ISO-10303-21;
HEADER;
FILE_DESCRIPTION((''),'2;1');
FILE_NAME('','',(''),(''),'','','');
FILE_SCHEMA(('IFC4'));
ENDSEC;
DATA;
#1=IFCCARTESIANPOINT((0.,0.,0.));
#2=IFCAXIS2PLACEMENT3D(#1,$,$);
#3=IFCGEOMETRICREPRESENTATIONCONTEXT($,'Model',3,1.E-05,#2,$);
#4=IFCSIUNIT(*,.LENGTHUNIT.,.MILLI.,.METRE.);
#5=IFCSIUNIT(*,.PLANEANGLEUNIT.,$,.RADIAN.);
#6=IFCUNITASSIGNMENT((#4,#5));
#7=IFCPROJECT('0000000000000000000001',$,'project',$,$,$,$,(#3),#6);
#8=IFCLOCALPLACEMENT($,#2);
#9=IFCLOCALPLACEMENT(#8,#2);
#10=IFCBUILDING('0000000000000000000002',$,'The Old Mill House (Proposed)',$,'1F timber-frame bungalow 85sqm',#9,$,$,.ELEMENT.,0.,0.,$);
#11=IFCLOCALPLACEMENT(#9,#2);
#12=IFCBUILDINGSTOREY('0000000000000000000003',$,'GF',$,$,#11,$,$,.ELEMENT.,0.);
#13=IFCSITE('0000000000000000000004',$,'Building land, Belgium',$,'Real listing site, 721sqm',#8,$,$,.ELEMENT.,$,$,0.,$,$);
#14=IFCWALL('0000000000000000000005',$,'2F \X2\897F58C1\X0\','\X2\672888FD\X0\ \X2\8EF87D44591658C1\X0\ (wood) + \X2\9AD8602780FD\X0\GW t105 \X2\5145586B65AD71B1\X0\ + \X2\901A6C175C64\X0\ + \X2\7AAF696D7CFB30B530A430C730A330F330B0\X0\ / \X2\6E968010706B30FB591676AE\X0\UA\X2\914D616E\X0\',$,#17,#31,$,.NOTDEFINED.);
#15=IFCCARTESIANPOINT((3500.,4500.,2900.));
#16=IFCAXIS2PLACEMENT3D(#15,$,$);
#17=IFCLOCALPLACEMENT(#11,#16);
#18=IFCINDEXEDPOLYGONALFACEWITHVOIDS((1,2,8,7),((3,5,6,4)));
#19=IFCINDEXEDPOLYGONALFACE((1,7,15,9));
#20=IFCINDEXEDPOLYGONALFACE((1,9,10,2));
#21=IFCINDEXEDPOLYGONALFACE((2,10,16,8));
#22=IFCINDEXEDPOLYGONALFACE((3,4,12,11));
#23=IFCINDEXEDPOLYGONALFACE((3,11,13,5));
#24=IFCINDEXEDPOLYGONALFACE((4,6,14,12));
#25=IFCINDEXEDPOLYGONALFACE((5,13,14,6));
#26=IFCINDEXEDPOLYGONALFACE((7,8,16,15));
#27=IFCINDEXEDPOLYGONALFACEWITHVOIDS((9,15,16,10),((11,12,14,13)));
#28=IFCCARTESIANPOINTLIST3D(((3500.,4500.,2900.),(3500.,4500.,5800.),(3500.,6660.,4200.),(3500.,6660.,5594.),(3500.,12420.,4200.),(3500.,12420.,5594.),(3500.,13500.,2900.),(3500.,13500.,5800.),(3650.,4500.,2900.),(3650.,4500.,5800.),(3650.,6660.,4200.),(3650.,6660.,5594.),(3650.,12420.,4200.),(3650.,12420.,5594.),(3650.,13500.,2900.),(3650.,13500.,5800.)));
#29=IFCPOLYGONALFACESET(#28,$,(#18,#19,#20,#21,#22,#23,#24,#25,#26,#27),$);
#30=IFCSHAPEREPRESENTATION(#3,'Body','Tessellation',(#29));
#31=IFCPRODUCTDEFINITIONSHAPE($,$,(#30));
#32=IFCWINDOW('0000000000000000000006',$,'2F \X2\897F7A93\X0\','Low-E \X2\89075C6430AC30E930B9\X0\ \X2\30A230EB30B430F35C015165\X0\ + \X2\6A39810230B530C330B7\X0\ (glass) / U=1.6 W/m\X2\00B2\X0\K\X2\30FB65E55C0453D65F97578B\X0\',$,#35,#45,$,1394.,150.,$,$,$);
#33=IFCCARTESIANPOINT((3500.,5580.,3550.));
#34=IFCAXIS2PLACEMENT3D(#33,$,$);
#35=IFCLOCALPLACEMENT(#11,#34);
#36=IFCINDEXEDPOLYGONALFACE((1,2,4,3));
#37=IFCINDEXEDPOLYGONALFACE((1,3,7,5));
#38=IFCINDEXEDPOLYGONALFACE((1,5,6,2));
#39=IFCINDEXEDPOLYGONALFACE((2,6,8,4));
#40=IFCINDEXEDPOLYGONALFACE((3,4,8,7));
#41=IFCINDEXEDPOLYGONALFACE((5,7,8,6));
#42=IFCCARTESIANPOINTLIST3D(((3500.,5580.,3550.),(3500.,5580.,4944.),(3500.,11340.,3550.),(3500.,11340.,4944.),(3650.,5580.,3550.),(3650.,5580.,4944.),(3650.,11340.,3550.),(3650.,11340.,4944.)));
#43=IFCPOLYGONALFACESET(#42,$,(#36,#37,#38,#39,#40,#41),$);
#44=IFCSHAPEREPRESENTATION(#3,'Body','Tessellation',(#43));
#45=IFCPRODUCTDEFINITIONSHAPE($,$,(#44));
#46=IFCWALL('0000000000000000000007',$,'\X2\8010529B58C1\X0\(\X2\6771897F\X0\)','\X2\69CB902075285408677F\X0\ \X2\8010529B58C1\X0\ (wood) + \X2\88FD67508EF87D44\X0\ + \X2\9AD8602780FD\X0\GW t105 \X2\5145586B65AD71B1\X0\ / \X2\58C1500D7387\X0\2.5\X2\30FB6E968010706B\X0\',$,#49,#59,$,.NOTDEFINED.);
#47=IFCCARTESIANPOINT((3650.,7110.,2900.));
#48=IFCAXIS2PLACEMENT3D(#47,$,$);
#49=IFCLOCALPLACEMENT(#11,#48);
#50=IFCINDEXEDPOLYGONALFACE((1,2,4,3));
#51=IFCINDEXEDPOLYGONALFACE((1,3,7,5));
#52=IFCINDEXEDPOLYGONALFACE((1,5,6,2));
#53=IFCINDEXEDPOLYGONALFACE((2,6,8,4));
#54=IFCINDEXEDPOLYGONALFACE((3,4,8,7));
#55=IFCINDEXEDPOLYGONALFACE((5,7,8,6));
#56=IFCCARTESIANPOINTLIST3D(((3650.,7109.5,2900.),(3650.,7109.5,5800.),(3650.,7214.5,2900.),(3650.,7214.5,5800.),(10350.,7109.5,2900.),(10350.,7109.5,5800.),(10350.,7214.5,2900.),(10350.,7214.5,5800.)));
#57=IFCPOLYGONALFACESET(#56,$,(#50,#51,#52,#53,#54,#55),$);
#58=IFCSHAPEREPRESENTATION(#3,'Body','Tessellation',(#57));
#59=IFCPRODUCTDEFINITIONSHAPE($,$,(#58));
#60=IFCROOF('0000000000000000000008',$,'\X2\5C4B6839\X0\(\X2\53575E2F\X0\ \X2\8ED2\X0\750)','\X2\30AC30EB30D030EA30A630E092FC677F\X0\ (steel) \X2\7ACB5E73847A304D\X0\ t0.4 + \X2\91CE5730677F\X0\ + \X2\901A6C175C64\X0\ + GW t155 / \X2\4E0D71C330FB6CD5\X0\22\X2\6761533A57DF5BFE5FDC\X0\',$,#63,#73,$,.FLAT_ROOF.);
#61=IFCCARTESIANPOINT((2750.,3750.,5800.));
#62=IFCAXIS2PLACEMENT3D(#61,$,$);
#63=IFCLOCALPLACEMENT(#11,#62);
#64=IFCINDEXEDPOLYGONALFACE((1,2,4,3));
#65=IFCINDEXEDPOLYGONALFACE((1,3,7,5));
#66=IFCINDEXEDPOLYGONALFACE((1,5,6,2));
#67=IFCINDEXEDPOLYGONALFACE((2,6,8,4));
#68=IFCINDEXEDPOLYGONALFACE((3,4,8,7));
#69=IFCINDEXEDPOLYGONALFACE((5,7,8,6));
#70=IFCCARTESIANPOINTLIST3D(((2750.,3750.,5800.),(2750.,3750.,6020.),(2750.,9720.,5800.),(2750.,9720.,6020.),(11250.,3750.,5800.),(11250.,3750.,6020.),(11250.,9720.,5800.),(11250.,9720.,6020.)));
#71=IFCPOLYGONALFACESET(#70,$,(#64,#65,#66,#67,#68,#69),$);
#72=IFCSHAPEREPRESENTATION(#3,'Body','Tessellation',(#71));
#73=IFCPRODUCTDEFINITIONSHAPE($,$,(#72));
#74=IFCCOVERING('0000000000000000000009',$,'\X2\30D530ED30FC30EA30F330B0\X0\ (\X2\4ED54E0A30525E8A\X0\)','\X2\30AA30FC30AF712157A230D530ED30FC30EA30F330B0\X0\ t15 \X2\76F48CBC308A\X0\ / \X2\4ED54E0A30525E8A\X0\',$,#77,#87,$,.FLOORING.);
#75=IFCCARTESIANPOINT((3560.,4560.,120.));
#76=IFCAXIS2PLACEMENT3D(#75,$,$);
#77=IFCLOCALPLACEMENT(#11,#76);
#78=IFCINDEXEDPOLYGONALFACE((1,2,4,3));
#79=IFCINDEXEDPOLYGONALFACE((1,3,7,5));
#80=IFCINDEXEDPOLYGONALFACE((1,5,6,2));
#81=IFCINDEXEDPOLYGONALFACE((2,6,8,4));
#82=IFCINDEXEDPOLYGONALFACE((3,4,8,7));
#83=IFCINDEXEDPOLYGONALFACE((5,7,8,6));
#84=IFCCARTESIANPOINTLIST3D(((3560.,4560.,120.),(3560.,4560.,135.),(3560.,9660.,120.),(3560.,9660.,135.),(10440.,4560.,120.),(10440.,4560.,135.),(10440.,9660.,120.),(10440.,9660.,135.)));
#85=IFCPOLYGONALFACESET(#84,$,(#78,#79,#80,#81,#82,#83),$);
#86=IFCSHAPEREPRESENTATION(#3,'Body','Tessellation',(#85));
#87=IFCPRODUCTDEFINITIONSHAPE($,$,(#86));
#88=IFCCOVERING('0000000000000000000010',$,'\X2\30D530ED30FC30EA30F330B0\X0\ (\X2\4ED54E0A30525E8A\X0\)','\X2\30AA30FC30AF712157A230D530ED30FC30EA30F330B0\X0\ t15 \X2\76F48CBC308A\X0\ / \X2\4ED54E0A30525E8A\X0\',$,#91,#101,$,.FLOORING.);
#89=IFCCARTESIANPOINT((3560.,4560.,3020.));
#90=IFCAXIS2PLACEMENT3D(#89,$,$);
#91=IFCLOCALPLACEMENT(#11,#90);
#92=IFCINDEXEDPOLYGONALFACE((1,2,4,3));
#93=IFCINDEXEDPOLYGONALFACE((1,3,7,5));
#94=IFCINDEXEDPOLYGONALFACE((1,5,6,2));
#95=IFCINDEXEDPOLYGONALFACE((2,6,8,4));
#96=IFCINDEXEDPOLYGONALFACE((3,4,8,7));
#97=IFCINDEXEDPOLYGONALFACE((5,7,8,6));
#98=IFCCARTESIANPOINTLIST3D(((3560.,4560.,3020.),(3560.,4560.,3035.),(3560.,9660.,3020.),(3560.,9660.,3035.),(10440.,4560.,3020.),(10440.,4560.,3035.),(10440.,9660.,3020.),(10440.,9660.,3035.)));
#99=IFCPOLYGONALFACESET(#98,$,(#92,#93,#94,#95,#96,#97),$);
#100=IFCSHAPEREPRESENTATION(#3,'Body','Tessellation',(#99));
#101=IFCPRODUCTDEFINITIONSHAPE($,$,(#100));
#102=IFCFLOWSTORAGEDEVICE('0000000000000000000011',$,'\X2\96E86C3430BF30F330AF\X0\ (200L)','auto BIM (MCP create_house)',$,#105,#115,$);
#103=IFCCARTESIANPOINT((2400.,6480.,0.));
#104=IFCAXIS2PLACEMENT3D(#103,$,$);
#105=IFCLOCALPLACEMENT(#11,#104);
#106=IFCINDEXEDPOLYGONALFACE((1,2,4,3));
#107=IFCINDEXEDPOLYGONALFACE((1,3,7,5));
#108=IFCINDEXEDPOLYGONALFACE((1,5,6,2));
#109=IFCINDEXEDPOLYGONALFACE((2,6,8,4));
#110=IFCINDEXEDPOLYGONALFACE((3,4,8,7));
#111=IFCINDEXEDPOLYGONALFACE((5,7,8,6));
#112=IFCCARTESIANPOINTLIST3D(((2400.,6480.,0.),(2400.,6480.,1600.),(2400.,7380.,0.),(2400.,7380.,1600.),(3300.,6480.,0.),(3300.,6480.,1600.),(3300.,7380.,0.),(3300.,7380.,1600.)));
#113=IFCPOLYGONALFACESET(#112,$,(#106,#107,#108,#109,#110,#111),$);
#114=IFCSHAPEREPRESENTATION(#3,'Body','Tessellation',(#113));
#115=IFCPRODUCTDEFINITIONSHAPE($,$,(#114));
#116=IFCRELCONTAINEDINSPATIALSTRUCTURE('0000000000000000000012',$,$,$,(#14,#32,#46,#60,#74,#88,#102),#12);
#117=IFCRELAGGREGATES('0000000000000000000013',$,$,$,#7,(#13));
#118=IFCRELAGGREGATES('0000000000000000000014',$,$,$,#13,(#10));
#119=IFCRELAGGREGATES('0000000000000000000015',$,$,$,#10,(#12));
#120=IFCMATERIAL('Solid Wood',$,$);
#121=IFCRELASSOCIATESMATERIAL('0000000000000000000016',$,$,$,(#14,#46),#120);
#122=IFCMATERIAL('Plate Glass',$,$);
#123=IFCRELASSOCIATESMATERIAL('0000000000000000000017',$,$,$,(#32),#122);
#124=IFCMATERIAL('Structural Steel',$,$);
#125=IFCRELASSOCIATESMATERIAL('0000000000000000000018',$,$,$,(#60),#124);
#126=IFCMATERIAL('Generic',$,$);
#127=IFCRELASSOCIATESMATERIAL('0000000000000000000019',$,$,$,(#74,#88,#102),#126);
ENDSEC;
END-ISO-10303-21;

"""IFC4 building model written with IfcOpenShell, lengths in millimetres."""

from ifc_helpers import new_model, si_unit, frame, frame_2d, origin, place, context, project, spatial, rectangle, extrude, material, element, fill, save


model = new_model("IFC4")

# Units and contexts
model_context = context("Model", 3, precision=1e-05, world=origin())
ifc_project = project(units=[si_unit("LENGTHUNIT", "METRE", prefix="MILLI"), si_unit("PLANEANGLEUNIT", "RADIAN")], contexts=[model_context])

# Site, building, storey
site_placement = place(None, origin())
site = spatial("IfcSite", under=ifc_project, at=site_placement, Name="Building land, Belgium", ObjectType="Real listing site, 721sqm", CompositionType="ELEMENT", RefElevation=0.0)
building_placement = place(site_placement, origin())
building = spatial("IfcBuilding", under=site, at=building_placement, Name="The Old Mill House (Proposed)", ObjectType="1F timber-frame bungalow 85sqm", CompositionType="ELEMENT", ElevationOfRefHeight=0.0, ElevationOfTerrain=0.0)
storey_placement = place(building_placement, origin())
storey = spatial("IfcBuildingStorey", under=building, at=storey_placement, Name="GF", CompositionType="ELEMENT", Elevation=0.0)

# Shared definitions
ifc_material_1 = material(Name="Solid Wood")
ifc_material_2 = material(Name="Generic")

# Shared definitions
ifc_material_3 = material(Name="Plate Glass")

# Wall, opening, window
wall_1_placement = place(storey_placement, frame((3500.0, 4500.0, 2900.0)))
wall_1 = element("IfcWall", 1, at=wall_1_placement, inside=storey, material=ifc_material_1, Name="2F 西壁", Description="木製 軸組外壁 (wood) + 高性能GW t105 充填断熱 + 通気層 + 窯業系サイディング / 準耐火・外皮UA配慮", PredefinedType="NOTDEFINED", context=model_context, shape_type="SweptSolid", body=[
    extrude(rectangle(XDim=150.0, YDim=9000.0, at=frame_2d((75.0, 4500.0))), frame((3500.0, 4500.0, 2900.0)), (0.0, 0.0, 1.0), 2900.0),
])
opening_1_placement = place(storey_placement, frame((3500.0, 5580.0, 3550.0)))
opening_1 = element("IfcOpeningElement", 2, at=opening_1_placement, cuts=wall_1, PredefinedType="NOTDEFINED", context=model_context, shape_type="SweptSolid", body=[
    extrude(rectangle(XDim=150.0, YDim=5760.0, at=frame_2d((75.0, 2880.0))), frame((3500.0, 5580.0, 3550.0)), (0.0, 0.0, 1.0), 1394.0),
])
window_1_placement = place(storey_placement, frame((3500.0, 5580.0, 3550.0)))
window_1 = element("IfcWindow", 3, at=window_1_placement, inside=storey, material=ifc_material_3, Name="2F 西窓", Description="Low-E 複層ガラス アルゴン封入 + 樹脂サッシ (glass) / U=1.6 W/m²K・日射取得型", OverallHeight=1394.0, OverallWidth=150.0, context=model_context, shape_type="SweptSolid", body=[
    extrude(rectangle(XDim=150.0, YDim=5760.0, at=frame_2d((75.0, 2880.0))), frame((3500.0, 5580.0, 3550.0)), (0.0, 0.0, 1.0), 1394.0),
])
fill(opening_1, window_1)

# Wall
wall_2_placement = place(storey_placement, frame((3650.0, 7110.0, 2900.0)))
element("IfcWall", 4, at=wall_2_placement, inside=storey, material=ifc_material_1, Name="耐力壁(東西)", Description="構造用合板 耐力壁 (wood) + 製材軸組 + 高性能GW t105 充填断熱 / 壁倍率2.5・準耐火", PredefinedType="NOTDEFINED", context=model_context, shape_type="SweptSolid", body=[
    extrude(rectangle(XDim=6700.0, YDim=105.0, at=frame_2d((3350.0, 52.0))), frame((3650.0, 7110.0, 2900.0)), (0.0, 0.0, 1.0), 2900.0),
])

# Roof
ifc_material_4 = material(Name="Structural Steel")
for number, where, name in (
    (5, (2750.0, 3750.0, 5800.0), "屋根(南帯 軒750)"),
):
    element("IfcRoof", number, at=place(storey_placement, frame(where)), inside=storey, material=ifc_material_4, Name=name, Description="ガルバリウム鋼板 (steel) 立平葺き t0.4 + 野地板 + 通気層 + GW t155 / 不燃・法22条区域対応", PredefinedType="FLAT_ROOF", context=model_context, shape_type="SweptSolid", body=[
        extrude(rectangle(XDim=8500.0, YDim=5970.0, at=frame_2d((4250.0, 2985.0))), frame((2750.0, 3750.0, 5800.0)), (0.0, 0.0, 1.0), 220.0),
    ])

# Coverings
covering_1_placement = place(storey_placement, frame((3560.0, 4560.0, 120.0)))
element("IfcCovering", 6, at=covering_1_placement, inside=storey, material=ifc_material_2, Name="フローリング (仕上げ床)", Description="オーク無垢フローリング t15 直貼り / 仕上げ床", PredefinedType="FLOORING", context=model_context, shape_type="SweptSolid", body=[
    extrude(rectangle(XDim=6880.0, YDim=5100.0, at=frame_2d((3440.0, 2550.0))), frame((3560.0, 4560.0, 120.0)), (0.0, 0.0, 1.0), 15.0),
])
covering_2_placement = place(storey_placement, frame((3560.0, 4560.0, 3020.0)))
element("IfcCovering", 7, at=covering_2_placement, inside=storey, material=ifc_material_2, Name="フローリング (仕上げ床)", Description="オーク無垢フローリング t15 直貼り / 仕上げ床", PredefinedType="FLOORING", context=model_context, shape_type="SweptSolid", body=[
    extrude(rectangle(XDim=6880.0, YDim=5100.0, at=frame_2d((3440.0, 2550.0))), frame((3560.0, 4560.0, 3020.0)), (0.0, 0.0, 1.0), 15.0),
])

# Flow storage device
flow_storage_device_placement = place(storey_placement, frame((2400.0, 6480.0, 0.0)))
element("IfcFlowStorageDevice", 8, at=flow_storage_device_placement, inside=storey, material=ifc_material_2, Name="雨水タンク (200L)", Description="auto BIM (MCP create_house)", context=model_context, shape_type="SweptSolid", body=[
    extrude(rectangle(XDim=900.0, YDim=900.0, at=frame_2d((450.0, 450.0))), frame((2400.0, 6480.0, 0.0)), (0.0, 0.0, 1.0), 1600.0),
])

save(model, "model.ifc")
